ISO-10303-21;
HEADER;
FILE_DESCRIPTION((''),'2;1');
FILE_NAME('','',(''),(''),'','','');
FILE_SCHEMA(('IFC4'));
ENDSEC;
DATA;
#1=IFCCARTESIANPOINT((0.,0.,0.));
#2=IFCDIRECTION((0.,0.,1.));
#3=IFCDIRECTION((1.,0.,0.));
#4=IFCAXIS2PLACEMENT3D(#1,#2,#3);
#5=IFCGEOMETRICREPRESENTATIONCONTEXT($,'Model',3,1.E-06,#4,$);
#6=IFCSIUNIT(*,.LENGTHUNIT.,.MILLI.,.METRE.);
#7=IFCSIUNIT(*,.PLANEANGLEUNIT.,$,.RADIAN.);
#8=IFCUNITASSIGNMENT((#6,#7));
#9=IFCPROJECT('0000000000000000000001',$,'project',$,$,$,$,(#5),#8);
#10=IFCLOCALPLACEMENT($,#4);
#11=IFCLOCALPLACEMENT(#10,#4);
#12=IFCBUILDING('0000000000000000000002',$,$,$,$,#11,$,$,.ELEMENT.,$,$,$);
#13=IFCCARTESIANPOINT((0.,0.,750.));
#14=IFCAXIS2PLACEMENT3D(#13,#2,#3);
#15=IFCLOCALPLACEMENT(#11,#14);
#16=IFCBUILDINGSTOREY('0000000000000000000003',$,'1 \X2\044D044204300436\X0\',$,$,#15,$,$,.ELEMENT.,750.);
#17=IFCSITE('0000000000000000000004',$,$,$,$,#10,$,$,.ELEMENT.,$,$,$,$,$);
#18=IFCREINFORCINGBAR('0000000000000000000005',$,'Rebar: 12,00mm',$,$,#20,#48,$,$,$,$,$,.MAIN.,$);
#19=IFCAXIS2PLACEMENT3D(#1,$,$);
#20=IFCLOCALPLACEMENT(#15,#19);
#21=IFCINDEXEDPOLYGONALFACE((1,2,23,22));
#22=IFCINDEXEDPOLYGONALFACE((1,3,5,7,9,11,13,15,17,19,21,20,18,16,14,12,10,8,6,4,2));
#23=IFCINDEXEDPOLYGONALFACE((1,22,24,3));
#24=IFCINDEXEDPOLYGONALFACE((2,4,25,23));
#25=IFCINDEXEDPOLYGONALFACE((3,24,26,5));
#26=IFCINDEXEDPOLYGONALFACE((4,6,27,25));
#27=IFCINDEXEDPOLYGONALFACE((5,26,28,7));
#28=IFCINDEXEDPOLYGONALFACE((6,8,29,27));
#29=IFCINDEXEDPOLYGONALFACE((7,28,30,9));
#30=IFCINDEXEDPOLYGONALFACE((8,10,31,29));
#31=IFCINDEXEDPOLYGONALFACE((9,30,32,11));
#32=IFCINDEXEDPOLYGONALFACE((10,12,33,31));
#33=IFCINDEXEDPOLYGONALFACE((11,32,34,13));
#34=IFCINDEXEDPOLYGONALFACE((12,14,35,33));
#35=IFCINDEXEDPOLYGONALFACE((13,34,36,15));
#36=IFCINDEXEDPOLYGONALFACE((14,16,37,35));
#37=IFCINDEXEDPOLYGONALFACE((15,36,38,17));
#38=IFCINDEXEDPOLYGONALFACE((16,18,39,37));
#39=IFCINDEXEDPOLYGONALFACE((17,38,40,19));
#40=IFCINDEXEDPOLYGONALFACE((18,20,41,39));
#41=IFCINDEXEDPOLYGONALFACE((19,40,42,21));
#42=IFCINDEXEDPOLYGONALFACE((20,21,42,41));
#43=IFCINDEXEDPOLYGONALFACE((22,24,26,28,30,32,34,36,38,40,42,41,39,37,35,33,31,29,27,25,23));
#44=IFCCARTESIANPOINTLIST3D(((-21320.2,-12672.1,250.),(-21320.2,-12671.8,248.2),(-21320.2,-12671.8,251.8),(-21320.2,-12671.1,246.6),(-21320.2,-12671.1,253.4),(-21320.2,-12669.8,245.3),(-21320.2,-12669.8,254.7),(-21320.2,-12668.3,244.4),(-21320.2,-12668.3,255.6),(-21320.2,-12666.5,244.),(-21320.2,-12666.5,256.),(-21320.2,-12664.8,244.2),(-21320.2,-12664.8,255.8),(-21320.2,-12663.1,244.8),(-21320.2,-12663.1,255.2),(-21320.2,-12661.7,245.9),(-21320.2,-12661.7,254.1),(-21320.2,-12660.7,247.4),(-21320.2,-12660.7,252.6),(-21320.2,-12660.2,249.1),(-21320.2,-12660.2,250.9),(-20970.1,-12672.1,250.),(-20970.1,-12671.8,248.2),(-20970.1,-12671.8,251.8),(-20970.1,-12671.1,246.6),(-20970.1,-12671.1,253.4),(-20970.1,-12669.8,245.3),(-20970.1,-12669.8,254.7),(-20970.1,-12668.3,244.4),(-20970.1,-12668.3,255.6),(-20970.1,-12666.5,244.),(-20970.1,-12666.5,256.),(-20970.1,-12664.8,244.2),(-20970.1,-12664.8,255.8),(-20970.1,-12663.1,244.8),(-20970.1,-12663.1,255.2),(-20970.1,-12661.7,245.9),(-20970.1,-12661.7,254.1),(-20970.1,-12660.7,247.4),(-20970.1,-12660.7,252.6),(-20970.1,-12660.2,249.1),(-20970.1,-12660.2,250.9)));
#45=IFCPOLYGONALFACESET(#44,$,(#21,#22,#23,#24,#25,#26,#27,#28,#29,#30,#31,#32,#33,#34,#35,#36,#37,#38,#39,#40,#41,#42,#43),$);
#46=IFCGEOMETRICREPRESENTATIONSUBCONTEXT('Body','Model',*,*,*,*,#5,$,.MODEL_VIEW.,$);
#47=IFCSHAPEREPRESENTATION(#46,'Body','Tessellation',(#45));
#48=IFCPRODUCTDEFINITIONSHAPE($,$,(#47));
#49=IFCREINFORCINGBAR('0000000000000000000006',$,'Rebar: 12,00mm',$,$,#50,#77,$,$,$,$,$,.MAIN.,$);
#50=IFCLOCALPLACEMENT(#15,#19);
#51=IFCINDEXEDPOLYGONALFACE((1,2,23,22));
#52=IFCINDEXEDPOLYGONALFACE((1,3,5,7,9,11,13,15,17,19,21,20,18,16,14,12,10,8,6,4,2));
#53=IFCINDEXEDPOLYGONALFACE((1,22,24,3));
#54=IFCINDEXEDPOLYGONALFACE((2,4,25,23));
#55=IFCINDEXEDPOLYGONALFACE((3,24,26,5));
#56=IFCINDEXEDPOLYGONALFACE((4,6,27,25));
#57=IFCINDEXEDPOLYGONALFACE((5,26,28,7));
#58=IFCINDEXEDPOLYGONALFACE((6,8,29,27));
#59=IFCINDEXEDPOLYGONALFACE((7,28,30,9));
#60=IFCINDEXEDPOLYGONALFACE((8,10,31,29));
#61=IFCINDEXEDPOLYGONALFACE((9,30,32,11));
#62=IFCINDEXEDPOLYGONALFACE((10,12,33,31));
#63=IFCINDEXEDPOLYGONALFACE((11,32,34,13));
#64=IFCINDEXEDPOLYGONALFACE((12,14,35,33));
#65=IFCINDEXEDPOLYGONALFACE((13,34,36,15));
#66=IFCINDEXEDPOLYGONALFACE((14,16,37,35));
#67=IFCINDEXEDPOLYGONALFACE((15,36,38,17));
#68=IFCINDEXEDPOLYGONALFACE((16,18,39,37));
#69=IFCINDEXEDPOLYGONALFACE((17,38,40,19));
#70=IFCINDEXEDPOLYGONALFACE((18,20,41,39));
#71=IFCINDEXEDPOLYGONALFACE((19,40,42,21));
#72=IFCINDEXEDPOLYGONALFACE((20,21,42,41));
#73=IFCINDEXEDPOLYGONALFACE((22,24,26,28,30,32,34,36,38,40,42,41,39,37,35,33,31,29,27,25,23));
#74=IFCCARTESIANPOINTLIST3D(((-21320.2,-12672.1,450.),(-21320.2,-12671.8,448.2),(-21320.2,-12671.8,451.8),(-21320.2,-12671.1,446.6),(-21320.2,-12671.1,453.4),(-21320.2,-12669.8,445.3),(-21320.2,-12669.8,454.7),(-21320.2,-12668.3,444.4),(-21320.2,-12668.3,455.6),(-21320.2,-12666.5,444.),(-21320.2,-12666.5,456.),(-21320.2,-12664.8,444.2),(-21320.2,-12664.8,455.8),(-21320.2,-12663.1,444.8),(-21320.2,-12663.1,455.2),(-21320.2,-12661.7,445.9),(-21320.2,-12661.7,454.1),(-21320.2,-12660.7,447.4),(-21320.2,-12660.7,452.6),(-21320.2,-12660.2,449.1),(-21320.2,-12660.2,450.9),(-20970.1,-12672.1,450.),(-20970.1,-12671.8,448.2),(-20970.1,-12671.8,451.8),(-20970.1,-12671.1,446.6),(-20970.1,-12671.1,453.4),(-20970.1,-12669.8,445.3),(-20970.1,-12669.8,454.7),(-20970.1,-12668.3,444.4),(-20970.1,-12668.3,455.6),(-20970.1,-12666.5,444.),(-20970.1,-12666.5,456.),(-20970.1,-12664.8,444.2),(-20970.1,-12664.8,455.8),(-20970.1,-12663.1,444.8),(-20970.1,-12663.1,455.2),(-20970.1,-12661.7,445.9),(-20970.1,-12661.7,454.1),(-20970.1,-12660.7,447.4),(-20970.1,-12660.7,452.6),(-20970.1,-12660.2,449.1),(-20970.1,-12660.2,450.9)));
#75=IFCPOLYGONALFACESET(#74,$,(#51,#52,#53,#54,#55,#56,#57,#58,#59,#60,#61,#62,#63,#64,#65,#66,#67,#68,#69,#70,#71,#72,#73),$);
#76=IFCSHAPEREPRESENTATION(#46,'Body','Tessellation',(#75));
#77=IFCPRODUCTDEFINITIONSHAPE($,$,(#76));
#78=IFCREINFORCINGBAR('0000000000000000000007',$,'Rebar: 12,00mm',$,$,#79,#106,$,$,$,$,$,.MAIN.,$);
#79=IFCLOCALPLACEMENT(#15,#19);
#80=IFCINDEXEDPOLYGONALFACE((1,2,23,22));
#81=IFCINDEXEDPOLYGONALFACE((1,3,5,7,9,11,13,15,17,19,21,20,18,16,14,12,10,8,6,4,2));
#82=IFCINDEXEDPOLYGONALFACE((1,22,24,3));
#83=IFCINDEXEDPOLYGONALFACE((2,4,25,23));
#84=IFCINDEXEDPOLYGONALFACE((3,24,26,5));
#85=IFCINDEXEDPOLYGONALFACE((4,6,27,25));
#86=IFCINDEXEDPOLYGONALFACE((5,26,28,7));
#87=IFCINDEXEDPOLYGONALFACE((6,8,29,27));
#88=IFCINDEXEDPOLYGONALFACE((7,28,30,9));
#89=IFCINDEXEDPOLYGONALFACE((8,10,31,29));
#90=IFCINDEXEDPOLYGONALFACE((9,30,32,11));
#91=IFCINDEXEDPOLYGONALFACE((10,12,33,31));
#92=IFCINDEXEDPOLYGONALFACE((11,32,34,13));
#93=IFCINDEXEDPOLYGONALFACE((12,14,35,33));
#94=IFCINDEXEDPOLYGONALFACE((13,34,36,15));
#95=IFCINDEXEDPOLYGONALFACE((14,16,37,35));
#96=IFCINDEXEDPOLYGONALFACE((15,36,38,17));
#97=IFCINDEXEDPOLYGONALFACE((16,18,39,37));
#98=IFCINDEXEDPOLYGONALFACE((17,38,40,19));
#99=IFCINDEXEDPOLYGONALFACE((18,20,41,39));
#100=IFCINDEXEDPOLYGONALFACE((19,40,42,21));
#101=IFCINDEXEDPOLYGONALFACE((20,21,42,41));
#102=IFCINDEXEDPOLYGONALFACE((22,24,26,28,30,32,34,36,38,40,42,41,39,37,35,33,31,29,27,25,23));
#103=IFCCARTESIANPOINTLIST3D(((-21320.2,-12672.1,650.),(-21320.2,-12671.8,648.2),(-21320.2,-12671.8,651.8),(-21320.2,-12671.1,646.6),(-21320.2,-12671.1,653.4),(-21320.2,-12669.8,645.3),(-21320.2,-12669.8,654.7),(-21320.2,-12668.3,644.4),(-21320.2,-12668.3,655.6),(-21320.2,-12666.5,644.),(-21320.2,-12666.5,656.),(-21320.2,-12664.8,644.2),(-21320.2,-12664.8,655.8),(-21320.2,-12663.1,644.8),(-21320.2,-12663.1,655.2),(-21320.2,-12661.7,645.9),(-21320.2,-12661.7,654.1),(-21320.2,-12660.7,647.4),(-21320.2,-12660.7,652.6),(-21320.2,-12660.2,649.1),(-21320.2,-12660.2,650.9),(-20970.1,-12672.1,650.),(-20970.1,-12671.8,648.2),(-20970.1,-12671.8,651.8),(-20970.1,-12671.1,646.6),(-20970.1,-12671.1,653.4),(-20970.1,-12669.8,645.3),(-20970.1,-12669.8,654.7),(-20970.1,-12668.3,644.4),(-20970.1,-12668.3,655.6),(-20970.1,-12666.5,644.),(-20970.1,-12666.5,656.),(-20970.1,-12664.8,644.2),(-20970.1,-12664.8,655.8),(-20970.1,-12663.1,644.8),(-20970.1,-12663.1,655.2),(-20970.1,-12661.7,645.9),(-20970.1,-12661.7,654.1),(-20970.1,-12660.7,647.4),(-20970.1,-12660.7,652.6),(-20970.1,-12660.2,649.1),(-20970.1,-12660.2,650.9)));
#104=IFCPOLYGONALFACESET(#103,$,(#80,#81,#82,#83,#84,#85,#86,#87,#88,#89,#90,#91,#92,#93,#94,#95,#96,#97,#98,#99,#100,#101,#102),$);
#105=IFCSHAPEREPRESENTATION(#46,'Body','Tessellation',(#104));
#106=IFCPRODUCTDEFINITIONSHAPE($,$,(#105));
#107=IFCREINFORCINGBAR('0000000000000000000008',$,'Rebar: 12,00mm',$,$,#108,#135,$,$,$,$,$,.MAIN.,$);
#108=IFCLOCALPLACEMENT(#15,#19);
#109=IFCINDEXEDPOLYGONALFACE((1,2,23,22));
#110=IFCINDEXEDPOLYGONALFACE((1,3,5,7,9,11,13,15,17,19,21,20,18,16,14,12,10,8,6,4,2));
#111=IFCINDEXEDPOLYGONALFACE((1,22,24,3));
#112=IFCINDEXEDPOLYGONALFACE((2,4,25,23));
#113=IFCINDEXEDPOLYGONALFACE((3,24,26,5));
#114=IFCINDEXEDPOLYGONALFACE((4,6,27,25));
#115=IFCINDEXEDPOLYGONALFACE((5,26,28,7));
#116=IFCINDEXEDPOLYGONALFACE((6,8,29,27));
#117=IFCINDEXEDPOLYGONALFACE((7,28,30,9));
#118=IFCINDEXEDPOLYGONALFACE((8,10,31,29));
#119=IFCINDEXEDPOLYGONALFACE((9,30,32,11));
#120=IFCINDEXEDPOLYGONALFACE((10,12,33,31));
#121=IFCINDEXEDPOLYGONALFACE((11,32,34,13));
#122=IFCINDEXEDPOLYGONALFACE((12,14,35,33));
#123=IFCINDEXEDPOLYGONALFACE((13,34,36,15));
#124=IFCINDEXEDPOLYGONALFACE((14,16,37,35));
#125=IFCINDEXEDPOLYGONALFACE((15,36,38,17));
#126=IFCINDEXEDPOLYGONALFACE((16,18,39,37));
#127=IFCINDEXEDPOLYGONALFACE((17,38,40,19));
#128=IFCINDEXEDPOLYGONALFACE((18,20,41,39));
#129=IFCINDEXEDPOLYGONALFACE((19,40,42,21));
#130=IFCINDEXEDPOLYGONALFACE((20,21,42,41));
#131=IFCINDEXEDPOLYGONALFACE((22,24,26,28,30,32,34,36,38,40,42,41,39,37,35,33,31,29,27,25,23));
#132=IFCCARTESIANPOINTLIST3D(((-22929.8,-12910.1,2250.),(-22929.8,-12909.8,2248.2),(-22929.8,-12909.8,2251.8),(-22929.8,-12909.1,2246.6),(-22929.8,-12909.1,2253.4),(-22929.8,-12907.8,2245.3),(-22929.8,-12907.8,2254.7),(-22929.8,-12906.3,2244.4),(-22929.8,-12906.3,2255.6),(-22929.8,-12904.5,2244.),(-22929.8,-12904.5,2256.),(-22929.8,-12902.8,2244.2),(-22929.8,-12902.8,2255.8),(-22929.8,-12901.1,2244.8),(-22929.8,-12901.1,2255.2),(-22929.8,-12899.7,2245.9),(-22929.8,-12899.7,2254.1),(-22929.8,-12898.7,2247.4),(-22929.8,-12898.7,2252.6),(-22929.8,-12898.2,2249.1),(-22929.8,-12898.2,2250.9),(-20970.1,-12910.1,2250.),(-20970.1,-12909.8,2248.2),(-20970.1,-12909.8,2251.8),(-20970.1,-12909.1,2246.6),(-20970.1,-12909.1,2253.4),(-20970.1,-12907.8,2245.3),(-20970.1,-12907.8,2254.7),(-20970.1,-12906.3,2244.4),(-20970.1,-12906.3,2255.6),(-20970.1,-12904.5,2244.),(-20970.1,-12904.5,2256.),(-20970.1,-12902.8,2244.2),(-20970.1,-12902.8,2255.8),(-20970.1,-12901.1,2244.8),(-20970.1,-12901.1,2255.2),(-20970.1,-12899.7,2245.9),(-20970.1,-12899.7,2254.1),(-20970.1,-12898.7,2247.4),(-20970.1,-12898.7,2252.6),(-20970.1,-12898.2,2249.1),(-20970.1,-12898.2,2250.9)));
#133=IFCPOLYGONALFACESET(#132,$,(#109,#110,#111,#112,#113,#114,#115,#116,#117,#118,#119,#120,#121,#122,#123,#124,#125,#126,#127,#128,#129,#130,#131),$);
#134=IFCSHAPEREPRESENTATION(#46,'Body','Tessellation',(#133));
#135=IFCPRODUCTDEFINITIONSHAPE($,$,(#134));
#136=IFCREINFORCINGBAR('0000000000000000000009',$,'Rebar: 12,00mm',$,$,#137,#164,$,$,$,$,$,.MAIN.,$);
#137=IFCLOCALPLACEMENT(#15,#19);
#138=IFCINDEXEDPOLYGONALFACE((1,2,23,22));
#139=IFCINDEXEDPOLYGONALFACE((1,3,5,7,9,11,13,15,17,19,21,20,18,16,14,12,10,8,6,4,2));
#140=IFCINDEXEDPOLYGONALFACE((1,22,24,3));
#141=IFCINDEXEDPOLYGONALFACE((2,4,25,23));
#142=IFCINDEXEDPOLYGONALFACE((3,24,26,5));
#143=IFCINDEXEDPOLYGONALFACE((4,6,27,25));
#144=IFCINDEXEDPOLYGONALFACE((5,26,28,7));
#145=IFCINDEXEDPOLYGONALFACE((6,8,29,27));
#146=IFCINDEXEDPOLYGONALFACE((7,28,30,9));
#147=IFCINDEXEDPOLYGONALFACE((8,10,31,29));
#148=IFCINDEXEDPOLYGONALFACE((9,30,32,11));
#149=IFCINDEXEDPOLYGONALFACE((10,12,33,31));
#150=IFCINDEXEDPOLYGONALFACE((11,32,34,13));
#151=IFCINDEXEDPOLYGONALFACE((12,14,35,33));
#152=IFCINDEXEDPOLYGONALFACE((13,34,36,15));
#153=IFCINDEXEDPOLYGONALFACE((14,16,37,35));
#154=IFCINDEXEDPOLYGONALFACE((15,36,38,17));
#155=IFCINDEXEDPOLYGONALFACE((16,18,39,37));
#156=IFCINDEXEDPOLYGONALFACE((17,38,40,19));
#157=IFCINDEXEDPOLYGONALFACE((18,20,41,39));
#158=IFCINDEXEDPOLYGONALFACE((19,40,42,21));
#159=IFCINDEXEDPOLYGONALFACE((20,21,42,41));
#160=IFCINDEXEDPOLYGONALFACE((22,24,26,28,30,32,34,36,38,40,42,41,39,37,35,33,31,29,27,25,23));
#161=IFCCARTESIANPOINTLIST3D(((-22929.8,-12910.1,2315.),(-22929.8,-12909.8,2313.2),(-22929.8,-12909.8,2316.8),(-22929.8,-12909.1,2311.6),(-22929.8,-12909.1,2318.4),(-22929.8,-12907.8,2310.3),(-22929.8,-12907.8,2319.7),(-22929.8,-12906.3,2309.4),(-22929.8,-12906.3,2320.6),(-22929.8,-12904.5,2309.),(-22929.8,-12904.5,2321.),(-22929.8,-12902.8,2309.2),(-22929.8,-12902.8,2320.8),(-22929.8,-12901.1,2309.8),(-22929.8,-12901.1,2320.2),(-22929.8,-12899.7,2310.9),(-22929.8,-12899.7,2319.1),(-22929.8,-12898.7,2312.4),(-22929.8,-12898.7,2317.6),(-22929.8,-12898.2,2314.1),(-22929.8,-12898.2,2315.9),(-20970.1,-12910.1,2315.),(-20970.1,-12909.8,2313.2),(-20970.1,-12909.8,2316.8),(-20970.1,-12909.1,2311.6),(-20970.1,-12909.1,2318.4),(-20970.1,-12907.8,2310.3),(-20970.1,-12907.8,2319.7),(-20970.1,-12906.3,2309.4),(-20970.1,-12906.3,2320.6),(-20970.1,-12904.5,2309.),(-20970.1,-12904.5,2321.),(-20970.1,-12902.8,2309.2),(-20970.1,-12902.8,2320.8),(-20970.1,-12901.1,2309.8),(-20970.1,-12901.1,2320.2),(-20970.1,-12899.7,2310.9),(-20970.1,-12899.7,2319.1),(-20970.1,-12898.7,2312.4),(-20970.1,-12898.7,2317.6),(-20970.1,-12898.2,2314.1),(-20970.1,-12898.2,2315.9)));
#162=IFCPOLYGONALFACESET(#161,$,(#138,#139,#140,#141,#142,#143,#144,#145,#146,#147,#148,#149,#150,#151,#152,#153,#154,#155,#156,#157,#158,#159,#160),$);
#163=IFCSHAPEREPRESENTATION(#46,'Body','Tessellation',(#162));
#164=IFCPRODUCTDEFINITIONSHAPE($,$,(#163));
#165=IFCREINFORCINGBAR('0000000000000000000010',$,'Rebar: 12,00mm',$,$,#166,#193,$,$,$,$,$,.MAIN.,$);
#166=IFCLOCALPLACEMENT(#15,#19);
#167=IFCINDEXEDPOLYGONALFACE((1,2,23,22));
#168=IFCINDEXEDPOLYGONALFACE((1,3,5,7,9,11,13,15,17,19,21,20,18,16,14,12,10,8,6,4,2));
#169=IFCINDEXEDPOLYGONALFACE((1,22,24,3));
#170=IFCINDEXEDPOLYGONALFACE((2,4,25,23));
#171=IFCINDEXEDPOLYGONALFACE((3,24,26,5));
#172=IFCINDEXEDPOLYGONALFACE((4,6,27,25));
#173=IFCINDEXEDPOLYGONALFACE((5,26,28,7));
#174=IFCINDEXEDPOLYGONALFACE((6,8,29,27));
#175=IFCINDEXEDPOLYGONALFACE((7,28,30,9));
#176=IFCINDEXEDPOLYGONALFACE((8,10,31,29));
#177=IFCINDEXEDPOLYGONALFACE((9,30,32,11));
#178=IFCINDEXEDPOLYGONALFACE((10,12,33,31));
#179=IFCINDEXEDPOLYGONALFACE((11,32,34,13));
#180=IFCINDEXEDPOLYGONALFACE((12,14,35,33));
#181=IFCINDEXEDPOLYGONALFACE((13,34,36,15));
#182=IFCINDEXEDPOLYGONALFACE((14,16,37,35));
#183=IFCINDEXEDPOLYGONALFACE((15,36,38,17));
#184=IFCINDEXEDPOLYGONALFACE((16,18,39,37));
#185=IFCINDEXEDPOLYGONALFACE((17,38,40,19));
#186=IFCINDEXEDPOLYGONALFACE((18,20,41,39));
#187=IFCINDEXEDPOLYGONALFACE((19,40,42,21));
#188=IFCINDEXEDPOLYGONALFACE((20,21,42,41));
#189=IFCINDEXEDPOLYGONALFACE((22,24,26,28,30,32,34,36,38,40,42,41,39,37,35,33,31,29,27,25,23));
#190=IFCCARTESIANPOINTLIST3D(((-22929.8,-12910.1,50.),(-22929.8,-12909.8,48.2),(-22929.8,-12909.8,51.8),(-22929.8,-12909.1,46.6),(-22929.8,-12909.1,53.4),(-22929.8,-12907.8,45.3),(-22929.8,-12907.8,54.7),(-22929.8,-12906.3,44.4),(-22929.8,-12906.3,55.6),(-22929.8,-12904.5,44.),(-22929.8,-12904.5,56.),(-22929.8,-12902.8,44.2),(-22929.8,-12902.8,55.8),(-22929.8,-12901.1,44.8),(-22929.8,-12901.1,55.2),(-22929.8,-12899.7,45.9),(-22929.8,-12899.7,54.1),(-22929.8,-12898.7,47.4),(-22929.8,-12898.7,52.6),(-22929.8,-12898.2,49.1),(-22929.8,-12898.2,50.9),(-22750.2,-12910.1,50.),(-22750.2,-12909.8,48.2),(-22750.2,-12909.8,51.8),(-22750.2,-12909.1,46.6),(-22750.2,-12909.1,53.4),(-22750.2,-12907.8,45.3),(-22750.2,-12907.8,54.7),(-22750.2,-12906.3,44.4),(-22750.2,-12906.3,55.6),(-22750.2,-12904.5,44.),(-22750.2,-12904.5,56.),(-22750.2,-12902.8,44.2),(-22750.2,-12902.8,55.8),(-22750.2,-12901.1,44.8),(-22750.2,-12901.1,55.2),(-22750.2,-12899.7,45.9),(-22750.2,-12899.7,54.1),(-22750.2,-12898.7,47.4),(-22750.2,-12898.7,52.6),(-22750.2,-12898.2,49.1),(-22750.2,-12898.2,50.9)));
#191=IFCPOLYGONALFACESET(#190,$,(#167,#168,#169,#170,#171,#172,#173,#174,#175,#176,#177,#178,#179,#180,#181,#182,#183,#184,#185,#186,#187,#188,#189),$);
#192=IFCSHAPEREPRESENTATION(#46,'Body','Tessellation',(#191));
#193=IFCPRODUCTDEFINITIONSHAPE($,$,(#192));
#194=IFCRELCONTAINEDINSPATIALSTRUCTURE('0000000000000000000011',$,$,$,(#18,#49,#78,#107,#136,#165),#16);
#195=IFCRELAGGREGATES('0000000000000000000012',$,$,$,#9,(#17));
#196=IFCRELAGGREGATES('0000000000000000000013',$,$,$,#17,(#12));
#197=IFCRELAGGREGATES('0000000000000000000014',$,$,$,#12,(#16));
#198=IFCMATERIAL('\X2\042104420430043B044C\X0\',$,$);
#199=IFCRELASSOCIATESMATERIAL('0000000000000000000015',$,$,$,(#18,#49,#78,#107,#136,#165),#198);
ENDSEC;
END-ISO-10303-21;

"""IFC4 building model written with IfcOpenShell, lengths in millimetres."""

from ifc_helpers import new_model, entity, si_unit, frame, origin_with_axes, place, context, subcontext, project, spatial, source, transform, mapped, material, element, save


model = new_model("IFC4")

# Units and contexts
model_context = context("Model", 3, precision=1e-06, world=origin_with_axes())
body_context = subcontext(model_context, "Body", "Model", "MODEL_VIEW")
ifc_project = project(units=[si_unit("LENGTHUNIT", "METRE", prefix="MILLI"), si_unit("PLANEANGLEUNIT", "RADIAN")], contexts=[model_context])

# Site, building, storey
site_placement = place(None, origin_with_axes())
site = spatial("IfcSite", under=ifc_project, at=site_placement, CompositionType="ELEMENT")
building_placement = place(site_placement, origin_with_axes())
building = spatial("IfcBuilding", under=site, at=building_placement, CompositionType="ELEMENT")
storey_placement = place(building_placement, frame((0.0, 0.0, 750.0), z_axis=(0.0, 0.0, 1.0), x_axis=(1.0, 0.0, 0.0)))
storey = spatial("IfcBuildingStorey", under=building, at=storey_placement, Name="1 этаж", CompositionType="ELEMENT", Elevation=750.0)

# Reinforcing bars
ifc_material = material(Name="Сталь")
shared_shape_1 = source(origin_with_axes(), body_context, "Body", "AdvancedSweptSolid", [
    entity("IfcSweptDiskSolid", entity("IfcIndexedPolyCurve", entity("IfcCartesianPointList3D", [[0.0, 0.0, 0.0], [350.1, 0.0, 0.0]]), [entity("IfcLineIndex", [1, 2])]), 6.0),
])
reinforcing_bar_1_placement = place(storey_placement, origin_with_axes())
element("IfcReinforcingBar", 1, at=reinforcing_bar_1_placement, inside=storey, material=ifc_material, Name="Rebar: 12,00mm", PredefinedType="MAIN", context=body_context, shape_type="MappedRepresentation", body=[
    mapped(shared_shape_1, transform((-20970.1, -12666.1, 250.0), x_axis=(-1.0, 0.0, 0.0), y_axis=(0.0, -1.0, 0.0), z_axis=(0.0, 0.0, 1.0), scale=1.0)),
])
reinforcing_bar_2_placement = place(storey_placement, origin_with_axes())
element("IfcReinforcingBar", 2, at=reinforcing_bar_2_placement, inside=storey, material=ifc_material, Name="Rebar: 12,00mm", PredefinedType="MAIN", context=body_context, shape_type="MappedRepresentation", body=[
    mapped(shared_shape_1, transform((-20970.1, -12666.1, 450.0), x_axis=(-1.0, 0.0, 0.0), y_axis=(0.0, -1.0, 0.0), z_axis=(0.0, 0.0, 1.0), scale=1.0)),
])
reinforcing_bar_3_placement = place(storey_placement, origin_with_axes())
element("IfcReinforcingBar", 3, at=reinforcing_bar_3_placement, inside=storey, material=ifc_material, Name="Rebar: 12,00mm", PredefinedType="MAIN", context=body_context, shape_type="MappedRepresentation", body=[
    mapped(shared_shape_1, transform((-20970.1, -12666.1, 650.0), x_axis=(-1.0, 0.0, 0.0), y_axis=(0.0, -1.0, 0.0), z_axis=(0.0, 0.0, 1.0), scale=1.0)),
])
shared_shape_2 = source(origin_with_axes(), body_context, "Body", "AdvancedSweptSolid", [
    entity("IfcSweptDiskSolid", entity("IfcIndexedPolyCurve", entity("IfcCartesianPointList3D", [[0.0, 0.0, 0.0], [1959.7, 0.0, 0.0]]), [entity("IfcLineIndex", [1, 2])]), 6.0),
])
reinforcing_bar_4_placement = place(storey_placement, origin_with_axes())
element("IfcReinforcingBar", 4, at=reinforcing_bar_4_placement, inside=storey, material=ifc_material, Name="Rebar: 12,00mm", PredefinedType="MAIN", context=body_context, shape_type="MappedRepresentation", body=[
    mapped(shared_shape_2, transform((-20970.1, -12904.1, 2250.0), x_axis=(-1.0, 0.0, 0.0), y_axis=(0.0, -1.0, 0.0), z_axis=(0.0, 0.0, 1.0), scale=1.0)),
])
reinforcing_bar_5_placement = place(storey_placement, origin_with_axes())
element("IfcReinforcingBar", 5, at=reinforcing_bar_5_placement, inside=storey, material=ifc_material, Name="Rebar: 12,00mm", PredefinedType="MAIN", context=body_context, shape_type="MappedRepresentation", body=[
    mapped(shared_shape_2, transform((-20970.1, -12904.1, 2315.0), x_axis=(-1.0, 0.0, 0.0), y_axis=(0.0, -1.0, 0.0), z_axis=(0.0, 0.0, 1.0), scale=1.0)),
])
shared_shape_3 = source(origin_with_axes(), body_context, "Body", "AdvancedSweptSolid", [
    entity("IfcSweptDiskSolid", entity("IfcIndexedPolyCurve", entity("IfcCartesianPointList3D", [[0.0, 0.0, 0.0], [179.7, 0.0, 0.0]]), [entity("IfcLineIndex", [1, 2])]), 6.0),
])
reinforcing_bar_6_placement = place(storey_placement, origin_with_axes())
element("IfcReinforcingBar", 6, at=reinforcing_bar_6_placement, inside=storey, material=ifc_material, Name="Rebar: 12,00mm", PredefinedType="MAIN", context=body_context, shape_type="MappedRepresentation", body=[
    mapped(shared_shape_3, transform((-22750.2, -12904.1, 50.0), x_axis=(-1.0, 0.0, 0.0), y_axis=(0.0, -1.0, 0.0), z_axis=(0.0, 0.0, 1.0), scale=1.0)),
])

save(model, "model.ifc")
